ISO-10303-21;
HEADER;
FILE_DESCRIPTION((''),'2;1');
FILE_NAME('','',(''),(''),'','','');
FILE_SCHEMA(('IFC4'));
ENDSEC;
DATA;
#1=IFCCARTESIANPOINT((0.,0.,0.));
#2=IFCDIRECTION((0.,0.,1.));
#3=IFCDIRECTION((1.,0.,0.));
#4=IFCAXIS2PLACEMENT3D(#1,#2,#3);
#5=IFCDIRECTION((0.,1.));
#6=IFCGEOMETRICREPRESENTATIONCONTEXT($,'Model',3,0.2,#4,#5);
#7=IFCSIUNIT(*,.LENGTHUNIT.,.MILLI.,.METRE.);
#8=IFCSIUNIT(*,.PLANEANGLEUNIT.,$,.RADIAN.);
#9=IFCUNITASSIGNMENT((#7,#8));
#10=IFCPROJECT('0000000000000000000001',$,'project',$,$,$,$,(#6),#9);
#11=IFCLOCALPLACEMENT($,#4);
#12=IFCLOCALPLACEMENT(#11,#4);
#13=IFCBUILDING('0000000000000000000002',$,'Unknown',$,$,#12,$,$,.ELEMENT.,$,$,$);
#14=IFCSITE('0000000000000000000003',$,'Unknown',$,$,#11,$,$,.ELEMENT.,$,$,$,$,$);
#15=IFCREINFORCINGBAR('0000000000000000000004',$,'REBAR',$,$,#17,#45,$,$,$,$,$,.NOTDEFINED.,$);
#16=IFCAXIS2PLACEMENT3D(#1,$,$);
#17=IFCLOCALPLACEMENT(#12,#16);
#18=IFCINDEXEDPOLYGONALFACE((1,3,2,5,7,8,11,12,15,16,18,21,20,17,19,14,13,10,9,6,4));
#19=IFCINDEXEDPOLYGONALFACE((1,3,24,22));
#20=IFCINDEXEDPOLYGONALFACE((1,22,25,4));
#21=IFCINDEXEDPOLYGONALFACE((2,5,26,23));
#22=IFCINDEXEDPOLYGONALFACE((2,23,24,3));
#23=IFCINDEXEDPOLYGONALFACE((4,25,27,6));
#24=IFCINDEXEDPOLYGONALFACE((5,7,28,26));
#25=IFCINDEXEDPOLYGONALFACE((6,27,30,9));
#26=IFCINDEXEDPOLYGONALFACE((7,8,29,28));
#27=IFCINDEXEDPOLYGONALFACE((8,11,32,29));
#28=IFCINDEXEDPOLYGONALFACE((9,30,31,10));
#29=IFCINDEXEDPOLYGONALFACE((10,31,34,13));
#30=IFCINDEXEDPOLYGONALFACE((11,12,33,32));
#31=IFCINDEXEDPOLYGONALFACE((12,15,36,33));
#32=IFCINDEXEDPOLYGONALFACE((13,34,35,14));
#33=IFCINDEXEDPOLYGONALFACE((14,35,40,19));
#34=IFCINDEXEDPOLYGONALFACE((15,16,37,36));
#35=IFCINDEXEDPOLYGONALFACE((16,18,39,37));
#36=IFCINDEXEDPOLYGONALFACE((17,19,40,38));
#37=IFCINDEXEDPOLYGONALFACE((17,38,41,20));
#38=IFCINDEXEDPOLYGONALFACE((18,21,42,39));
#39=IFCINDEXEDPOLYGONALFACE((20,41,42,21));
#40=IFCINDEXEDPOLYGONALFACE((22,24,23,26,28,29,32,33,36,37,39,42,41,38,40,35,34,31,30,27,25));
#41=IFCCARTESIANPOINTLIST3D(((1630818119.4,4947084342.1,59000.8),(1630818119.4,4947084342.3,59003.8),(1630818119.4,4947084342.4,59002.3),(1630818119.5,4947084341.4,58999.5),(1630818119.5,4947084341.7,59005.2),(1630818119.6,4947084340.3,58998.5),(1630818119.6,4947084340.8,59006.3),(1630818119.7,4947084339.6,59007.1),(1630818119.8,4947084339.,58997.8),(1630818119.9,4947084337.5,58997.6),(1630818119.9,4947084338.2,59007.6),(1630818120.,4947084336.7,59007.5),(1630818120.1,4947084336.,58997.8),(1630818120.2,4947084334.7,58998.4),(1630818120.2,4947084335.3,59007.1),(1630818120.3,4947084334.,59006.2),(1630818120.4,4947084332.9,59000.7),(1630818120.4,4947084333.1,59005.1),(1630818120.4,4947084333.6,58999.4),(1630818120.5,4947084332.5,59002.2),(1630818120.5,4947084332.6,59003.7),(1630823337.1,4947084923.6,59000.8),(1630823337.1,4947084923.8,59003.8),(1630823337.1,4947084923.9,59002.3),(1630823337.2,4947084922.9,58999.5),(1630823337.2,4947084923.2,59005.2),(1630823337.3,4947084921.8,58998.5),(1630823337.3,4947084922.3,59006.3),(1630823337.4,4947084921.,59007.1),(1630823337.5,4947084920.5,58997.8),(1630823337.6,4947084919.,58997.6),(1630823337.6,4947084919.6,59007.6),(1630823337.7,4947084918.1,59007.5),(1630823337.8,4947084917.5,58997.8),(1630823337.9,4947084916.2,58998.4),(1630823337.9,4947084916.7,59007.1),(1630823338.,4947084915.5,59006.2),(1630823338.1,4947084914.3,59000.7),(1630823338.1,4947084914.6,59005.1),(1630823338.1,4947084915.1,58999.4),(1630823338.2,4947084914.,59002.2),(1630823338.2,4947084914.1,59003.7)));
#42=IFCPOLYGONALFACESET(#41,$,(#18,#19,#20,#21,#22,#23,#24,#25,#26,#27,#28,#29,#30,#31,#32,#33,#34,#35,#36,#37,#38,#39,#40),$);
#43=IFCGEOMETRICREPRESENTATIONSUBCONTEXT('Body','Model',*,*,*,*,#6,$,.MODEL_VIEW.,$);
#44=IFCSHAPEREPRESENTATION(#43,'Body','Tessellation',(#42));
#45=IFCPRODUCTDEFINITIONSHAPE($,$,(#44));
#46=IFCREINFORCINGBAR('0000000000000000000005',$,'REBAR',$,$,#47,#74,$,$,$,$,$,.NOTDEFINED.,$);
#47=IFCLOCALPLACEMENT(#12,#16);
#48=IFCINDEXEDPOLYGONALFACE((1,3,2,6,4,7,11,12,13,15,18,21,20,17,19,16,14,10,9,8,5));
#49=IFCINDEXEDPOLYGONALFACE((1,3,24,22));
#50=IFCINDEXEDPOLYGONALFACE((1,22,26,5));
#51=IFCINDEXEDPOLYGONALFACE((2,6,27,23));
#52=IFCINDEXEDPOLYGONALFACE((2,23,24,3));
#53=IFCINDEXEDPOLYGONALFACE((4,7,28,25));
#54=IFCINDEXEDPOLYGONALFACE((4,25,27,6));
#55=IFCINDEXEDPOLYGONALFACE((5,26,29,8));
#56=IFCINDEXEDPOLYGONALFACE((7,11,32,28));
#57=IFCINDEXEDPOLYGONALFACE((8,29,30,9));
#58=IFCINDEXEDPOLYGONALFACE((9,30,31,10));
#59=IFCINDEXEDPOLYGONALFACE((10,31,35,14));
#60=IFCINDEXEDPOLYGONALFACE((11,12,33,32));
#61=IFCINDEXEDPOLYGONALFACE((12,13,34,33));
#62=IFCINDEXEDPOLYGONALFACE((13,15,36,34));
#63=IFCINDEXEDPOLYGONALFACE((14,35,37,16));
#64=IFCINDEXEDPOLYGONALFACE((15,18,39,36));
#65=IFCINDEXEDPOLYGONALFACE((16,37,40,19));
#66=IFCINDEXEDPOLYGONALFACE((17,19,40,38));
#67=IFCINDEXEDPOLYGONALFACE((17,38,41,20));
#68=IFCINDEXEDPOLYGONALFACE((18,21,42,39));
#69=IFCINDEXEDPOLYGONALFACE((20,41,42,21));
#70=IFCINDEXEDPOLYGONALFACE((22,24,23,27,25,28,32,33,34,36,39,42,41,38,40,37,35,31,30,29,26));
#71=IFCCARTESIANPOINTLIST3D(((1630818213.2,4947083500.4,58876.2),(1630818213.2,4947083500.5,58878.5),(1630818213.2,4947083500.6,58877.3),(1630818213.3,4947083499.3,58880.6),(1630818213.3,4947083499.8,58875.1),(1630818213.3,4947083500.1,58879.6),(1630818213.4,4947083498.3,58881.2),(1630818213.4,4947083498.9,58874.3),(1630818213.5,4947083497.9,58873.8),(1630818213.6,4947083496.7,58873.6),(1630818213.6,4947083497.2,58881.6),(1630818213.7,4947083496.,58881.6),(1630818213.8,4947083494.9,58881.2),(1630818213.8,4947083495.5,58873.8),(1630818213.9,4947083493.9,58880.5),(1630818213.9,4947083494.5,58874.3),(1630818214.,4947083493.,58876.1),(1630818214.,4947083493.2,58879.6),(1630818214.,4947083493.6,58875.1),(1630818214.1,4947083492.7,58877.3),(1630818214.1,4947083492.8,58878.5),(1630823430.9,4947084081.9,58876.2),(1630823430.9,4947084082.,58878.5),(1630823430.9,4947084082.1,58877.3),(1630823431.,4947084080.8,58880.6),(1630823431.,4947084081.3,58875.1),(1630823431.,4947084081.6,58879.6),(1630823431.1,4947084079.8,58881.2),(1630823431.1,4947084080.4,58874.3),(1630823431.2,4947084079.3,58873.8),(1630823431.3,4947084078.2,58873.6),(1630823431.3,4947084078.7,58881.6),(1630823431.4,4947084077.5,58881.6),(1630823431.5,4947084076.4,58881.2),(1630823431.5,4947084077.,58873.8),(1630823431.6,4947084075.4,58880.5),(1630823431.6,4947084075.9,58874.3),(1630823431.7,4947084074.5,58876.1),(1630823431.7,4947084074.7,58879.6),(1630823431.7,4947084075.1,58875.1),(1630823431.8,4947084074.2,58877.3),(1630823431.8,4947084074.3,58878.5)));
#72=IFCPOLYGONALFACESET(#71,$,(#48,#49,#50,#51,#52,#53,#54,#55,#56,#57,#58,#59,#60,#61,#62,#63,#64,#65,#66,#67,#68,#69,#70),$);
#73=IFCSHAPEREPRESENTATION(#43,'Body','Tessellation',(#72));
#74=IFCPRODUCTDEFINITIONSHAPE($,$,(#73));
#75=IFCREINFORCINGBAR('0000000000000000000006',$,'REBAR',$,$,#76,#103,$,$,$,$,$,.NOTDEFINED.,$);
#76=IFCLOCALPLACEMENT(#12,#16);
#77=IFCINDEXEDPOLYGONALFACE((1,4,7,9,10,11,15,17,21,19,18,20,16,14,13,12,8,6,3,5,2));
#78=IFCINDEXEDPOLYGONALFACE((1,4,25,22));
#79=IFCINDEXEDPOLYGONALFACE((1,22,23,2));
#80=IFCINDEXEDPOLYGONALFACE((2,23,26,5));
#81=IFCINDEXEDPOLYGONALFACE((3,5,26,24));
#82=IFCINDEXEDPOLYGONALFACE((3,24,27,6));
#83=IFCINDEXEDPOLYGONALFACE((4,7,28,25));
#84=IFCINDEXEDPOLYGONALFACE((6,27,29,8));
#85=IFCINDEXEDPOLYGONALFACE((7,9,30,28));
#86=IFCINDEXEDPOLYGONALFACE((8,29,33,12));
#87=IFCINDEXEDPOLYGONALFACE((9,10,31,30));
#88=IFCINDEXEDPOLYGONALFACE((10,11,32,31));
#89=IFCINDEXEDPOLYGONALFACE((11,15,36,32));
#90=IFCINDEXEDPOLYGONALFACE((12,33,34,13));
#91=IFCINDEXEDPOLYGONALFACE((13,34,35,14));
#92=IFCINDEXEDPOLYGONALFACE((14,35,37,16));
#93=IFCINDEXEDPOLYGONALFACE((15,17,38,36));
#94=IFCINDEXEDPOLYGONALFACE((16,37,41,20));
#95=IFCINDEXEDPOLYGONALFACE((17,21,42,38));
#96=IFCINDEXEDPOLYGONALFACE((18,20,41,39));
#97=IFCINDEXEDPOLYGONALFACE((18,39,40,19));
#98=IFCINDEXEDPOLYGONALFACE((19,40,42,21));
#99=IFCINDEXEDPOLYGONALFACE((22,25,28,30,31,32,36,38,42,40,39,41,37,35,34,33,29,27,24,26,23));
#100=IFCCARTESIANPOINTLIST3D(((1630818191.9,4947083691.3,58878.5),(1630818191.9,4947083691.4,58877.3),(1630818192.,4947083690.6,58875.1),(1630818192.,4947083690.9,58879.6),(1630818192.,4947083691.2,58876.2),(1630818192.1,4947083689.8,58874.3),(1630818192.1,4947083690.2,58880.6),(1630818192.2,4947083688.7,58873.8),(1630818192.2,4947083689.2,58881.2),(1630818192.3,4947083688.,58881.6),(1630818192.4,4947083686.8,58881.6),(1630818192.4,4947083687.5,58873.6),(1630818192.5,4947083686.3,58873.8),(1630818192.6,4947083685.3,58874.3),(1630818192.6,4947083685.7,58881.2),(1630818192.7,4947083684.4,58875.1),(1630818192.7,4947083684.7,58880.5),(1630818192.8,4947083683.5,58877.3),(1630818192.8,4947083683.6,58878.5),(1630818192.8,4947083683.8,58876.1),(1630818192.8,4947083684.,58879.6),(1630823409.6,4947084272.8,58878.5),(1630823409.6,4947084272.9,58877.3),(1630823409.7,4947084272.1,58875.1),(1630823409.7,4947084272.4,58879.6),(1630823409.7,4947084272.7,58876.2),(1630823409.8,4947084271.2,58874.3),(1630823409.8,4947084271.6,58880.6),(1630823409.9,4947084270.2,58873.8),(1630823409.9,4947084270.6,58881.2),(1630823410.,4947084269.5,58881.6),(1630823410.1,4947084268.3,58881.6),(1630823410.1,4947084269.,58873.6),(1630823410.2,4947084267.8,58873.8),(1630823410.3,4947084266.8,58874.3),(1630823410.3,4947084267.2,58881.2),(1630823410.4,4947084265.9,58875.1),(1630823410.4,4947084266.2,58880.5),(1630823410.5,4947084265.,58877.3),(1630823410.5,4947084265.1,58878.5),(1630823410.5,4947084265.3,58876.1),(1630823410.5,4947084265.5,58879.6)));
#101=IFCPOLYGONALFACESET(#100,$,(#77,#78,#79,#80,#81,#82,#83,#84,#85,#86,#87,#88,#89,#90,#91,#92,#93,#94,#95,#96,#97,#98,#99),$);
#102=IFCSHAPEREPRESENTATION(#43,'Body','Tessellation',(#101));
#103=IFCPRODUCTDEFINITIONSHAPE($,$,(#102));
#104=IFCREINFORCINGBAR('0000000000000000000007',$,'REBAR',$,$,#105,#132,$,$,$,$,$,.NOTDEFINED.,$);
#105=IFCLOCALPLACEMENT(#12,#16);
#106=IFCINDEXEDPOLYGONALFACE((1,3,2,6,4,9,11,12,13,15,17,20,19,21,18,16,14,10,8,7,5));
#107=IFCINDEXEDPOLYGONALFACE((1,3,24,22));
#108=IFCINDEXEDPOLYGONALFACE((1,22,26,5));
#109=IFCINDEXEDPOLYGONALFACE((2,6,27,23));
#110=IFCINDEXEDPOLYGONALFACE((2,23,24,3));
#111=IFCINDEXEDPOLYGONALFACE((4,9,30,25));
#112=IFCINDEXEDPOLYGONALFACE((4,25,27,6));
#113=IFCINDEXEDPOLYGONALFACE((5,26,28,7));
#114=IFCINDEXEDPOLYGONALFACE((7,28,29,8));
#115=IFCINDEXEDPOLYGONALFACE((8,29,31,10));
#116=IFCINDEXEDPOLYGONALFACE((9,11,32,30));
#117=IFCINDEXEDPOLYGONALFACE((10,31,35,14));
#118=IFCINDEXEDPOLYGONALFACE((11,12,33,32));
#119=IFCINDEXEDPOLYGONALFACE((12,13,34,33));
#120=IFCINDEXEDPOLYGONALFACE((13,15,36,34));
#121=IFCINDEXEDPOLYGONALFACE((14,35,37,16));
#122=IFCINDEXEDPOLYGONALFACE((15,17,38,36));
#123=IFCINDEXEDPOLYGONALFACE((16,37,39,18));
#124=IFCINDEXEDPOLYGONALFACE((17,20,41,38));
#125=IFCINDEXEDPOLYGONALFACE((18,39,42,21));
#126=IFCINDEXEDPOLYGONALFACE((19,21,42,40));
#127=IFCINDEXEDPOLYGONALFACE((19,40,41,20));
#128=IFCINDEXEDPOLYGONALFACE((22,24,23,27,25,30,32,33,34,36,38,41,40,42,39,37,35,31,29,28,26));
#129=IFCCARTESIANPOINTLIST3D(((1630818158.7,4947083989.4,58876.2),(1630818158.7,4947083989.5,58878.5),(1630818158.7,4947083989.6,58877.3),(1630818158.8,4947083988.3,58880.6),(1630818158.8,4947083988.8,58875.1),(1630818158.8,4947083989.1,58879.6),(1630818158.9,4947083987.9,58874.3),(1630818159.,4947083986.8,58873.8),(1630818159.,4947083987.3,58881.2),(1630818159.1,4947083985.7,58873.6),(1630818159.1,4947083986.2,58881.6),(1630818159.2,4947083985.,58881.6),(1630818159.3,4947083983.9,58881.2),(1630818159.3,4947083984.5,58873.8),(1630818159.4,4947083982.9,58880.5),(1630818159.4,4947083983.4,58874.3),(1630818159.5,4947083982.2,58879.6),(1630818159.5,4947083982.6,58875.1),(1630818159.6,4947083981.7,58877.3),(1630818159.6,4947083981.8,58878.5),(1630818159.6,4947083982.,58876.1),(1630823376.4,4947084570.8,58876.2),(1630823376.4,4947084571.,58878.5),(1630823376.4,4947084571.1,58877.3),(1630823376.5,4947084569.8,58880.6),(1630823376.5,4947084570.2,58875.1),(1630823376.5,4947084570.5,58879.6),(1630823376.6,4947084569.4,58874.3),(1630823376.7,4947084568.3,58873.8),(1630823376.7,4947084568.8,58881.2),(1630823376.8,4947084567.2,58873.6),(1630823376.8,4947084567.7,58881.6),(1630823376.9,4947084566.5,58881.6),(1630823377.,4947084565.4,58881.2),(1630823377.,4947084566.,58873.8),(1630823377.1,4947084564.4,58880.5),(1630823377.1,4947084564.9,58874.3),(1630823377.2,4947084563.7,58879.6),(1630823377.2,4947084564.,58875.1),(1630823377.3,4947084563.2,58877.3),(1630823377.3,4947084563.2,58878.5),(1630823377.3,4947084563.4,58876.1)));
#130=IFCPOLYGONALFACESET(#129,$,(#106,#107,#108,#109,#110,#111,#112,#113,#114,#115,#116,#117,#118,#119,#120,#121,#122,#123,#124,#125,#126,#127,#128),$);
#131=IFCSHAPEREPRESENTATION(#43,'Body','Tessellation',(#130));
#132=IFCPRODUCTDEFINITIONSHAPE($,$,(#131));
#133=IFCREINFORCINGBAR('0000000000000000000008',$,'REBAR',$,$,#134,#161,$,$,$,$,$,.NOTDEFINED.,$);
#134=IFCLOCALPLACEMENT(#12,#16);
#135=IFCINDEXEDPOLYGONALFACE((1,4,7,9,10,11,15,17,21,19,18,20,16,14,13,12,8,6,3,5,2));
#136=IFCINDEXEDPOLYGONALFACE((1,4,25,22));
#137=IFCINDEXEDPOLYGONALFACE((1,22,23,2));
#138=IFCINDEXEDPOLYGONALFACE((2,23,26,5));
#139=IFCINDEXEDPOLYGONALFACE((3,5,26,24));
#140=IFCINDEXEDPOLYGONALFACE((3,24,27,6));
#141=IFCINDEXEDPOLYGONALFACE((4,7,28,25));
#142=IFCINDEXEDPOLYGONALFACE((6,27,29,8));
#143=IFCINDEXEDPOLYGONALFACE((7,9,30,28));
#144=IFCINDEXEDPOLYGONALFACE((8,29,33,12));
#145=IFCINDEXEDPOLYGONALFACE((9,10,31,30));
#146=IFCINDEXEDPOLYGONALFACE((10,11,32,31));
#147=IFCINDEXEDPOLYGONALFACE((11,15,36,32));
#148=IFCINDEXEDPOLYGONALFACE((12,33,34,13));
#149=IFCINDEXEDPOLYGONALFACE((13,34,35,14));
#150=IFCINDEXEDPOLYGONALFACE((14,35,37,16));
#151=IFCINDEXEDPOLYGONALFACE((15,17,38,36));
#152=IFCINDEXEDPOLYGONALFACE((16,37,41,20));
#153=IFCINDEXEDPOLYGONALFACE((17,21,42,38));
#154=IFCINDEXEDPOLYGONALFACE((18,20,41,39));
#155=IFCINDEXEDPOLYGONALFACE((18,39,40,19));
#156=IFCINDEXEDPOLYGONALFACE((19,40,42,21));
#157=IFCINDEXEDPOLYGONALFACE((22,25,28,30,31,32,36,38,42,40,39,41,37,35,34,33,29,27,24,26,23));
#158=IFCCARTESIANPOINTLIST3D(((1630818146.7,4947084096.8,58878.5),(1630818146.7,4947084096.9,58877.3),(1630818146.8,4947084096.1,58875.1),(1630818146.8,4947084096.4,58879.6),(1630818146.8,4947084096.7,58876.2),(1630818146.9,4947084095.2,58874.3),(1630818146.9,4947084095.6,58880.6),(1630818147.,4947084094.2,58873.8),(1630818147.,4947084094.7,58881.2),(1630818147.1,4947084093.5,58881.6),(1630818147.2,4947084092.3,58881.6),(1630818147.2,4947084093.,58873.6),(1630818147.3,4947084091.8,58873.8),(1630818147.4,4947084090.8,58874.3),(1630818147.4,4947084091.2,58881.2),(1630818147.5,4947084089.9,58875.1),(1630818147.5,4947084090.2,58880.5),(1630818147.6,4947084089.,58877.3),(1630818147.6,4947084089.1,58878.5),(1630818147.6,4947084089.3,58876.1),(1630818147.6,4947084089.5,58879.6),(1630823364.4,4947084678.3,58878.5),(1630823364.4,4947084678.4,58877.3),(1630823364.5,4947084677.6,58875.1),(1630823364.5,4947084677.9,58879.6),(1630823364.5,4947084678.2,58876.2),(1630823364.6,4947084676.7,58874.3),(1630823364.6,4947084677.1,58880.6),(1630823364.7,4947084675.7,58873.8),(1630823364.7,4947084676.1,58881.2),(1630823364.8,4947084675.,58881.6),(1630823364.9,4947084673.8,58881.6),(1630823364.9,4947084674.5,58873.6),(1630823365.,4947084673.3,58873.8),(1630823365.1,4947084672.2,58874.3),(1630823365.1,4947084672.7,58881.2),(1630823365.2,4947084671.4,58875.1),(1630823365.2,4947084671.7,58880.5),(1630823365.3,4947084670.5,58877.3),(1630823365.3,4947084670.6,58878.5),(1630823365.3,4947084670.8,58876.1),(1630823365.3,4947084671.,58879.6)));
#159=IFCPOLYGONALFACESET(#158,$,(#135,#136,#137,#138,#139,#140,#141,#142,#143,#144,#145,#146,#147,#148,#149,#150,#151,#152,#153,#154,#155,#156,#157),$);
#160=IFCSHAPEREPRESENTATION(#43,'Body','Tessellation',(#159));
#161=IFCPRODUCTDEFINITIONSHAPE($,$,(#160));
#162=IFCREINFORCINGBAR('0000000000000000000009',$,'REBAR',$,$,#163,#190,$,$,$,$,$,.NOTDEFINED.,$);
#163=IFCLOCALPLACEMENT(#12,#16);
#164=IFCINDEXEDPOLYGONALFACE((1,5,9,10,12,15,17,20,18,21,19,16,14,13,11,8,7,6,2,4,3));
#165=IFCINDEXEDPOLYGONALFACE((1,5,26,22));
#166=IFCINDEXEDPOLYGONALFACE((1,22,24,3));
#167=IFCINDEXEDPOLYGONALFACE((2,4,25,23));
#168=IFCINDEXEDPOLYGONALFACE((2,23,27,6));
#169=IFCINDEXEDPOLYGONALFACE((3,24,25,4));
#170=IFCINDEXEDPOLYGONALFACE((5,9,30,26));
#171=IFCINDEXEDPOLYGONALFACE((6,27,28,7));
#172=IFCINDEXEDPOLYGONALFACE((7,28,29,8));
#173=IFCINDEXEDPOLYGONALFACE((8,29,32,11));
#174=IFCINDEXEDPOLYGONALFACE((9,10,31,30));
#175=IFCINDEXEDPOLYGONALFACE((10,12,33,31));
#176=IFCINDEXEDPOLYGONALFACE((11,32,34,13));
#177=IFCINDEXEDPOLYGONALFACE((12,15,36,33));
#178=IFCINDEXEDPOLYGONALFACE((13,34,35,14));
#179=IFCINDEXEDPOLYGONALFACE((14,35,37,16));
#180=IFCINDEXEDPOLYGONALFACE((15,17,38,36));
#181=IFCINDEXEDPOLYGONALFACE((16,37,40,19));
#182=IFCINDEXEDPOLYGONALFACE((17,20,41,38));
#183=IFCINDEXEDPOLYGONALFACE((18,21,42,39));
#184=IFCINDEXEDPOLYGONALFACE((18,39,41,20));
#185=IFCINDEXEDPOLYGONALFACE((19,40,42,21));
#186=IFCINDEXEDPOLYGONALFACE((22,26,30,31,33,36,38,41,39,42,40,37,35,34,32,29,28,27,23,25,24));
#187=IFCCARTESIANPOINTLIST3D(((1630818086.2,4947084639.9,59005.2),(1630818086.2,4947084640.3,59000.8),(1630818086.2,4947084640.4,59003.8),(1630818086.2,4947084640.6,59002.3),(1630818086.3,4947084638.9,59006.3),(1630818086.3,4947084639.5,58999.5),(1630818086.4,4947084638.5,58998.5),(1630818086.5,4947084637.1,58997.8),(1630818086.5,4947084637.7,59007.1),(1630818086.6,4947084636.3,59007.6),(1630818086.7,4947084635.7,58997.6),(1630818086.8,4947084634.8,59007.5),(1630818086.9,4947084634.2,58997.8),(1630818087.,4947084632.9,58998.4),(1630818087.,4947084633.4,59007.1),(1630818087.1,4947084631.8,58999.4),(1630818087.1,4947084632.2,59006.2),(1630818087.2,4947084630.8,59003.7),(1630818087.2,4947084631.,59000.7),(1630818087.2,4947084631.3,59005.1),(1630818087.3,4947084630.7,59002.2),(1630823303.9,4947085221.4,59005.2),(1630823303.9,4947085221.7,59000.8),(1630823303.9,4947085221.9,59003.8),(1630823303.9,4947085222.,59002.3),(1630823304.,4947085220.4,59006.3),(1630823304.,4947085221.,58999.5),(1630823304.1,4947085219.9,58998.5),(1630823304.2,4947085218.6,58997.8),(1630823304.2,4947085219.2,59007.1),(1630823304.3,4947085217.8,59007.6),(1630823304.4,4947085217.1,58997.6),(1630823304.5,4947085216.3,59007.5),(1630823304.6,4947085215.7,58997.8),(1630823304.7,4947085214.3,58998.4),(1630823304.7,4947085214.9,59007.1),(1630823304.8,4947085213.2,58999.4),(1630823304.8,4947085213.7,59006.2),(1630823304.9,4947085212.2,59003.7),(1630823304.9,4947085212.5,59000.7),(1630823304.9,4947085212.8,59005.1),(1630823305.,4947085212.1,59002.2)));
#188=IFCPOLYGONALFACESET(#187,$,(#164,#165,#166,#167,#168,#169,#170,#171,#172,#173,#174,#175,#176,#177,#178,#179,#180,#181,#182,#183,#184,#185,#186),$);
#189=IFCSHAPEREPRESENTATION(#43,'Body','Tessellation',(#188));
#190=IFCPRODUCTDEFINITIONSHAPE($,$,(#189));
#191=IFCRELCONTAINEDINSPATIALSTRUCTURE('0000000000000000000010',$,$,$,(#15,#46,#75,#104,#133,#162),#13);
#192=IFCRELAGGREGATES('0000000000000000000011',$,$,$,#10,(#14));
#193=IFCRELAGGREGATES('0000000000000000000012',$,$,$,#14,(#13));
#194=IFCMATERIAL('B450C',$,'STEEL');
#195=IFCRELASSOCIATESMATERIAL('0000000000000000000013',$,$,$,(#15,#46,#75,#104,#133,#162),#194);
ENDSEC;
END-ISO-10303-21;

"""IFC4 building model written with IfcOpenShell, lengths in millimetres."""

from ifc_helpers import new_model, entity, si_unit, direction, frame, origin_with_axes, place, context, subcontext, project, spatial, material, element, save


model = new_model("IFC4")

# Units and contexts
model_context = context("Model", 3, precision=0.2, world=origin_with_axes(), true_north=direction((0.0, 1.0)))
body_context = subcontext(model_context, "Body", "Model", "MODEL_VIEW")
ifc_project = project(units=[si_unit("LENGTHUNIT", "METRE", prefix="MILLI"), si_unit("PLANEANGLEUNIT", "RADIAN")], contexts=[model_context])

# Site, building
site_placement = place(None, origin_with_axes())
site = spatial("IfcSite", under=ifc_project, at=site_placement, Name="Unknown", CompositionType="ELEMENT")
building_placement = place(site_placement, origin_with_axes())
building = spatial("IfcBuilding", under=site, at=building_placement, Name="Unknown", CompositionType="ELEMENT")

# Reinforcing bars
ifc_material = material(Name="B450C", Category="STEEL")
for number, where, z_axis, x_axis, name in (
    (1, (1630818119.9, 4947084337.5, 59002.6), (-0.007106, 0.063762, 0.99794), (0.993847, 0.110757, 0.0), "REBAR"),
):
    element("IfcReinforcingBar", number, at=place(building_placement, frame(where, z_axis=z_axis, x_axis=x_axis)), inside=building, material=ifc_material, Name=name, PredefinedType="NOTDEFINED", context=body_context, shape_type="AdvancedSweptSolid", body=[
        entity("IfcSweptDiskSolid", entity("IfcIndexedPolyCurve", entity("IfcCartesianPointList3D", [[0.0, 0.0, 0.0], [5250.0, 0.0, 0.0]]), [entity("IfcLineIndex", [1, 2])]), 5.0),
    ])
for number, where, z_axis, x_axis, name in (
    (2, (1630818213.6, 4947083496.7, 58877.6), (-0.007106, 0.063762, 0.99794), (0.993847, 0.110757, 0.0), "REBAR"),
    (3, (1630818192.4, 4947083687.5, 58877.6), (-0.007106, 0.063762, 0.99794), (0.993847, 0.110757, 0.0), "REBAR"),
    (4, (1630818159.1, 4947083985.6, 58877.6), (-0.007106, 0.063762, 0.99794), (0.993847, 0.110757, 0.0), "REBAR"),
    (5, (1630818147.2, 4947084093.0, 58877.6), (-0.007106, 0.063762, 0.99794), (0.993847, 0.110757, 0.0), "REBAR"),
):
    element("IfcReinforcingBar", number, at=place(building_placement, frame(where, z_axis=z_axis, x_axis=x_axis)), inside=building, material=ifc_material, Name=name, PredefinedType="NOTDEFINED", context=body_context, shape_type="AdvancedSweptSolid", body=[
        entity("IfcSweptDiskSolid", entity("IfcIndexedPolyCurve", entity("IfcCartesianPointList3D", [[0.0, 0.0, 0.0], [5250.0, 0.0, 0.0]]), [entity("IfcLineIndex", [1, 2])]), 4.0),
    ])
reinforcing_bar_1_placement = place(building_placement, frame((1630818086.7, 4947084635.6, 59002.6), z_axis=(-0.007106, 0.063762, 0.99794), x_axis=(0.993847, 0.110757, 0.0)))
element("IfcReinforcingBar", 6, at=reinforcing_bar_1_placement, inside=building, material=ifc_material, Name="REBAR", PredefinedType="NOTDEFINED", context=body_context, shape_type="AdvancedSweptSolid", body=[
    entity("IfcSweptDiskSolid", entity("IfcIndexedPolyCurve", entity("IfcCartesianPointList3D", [[0.0, 0.0, 0.0], [5250.0, 0.0, 0.0]]), [entity("IfcLineIndex", [1, 2])]), 5.0),
])

save(model, "model.ifc")
